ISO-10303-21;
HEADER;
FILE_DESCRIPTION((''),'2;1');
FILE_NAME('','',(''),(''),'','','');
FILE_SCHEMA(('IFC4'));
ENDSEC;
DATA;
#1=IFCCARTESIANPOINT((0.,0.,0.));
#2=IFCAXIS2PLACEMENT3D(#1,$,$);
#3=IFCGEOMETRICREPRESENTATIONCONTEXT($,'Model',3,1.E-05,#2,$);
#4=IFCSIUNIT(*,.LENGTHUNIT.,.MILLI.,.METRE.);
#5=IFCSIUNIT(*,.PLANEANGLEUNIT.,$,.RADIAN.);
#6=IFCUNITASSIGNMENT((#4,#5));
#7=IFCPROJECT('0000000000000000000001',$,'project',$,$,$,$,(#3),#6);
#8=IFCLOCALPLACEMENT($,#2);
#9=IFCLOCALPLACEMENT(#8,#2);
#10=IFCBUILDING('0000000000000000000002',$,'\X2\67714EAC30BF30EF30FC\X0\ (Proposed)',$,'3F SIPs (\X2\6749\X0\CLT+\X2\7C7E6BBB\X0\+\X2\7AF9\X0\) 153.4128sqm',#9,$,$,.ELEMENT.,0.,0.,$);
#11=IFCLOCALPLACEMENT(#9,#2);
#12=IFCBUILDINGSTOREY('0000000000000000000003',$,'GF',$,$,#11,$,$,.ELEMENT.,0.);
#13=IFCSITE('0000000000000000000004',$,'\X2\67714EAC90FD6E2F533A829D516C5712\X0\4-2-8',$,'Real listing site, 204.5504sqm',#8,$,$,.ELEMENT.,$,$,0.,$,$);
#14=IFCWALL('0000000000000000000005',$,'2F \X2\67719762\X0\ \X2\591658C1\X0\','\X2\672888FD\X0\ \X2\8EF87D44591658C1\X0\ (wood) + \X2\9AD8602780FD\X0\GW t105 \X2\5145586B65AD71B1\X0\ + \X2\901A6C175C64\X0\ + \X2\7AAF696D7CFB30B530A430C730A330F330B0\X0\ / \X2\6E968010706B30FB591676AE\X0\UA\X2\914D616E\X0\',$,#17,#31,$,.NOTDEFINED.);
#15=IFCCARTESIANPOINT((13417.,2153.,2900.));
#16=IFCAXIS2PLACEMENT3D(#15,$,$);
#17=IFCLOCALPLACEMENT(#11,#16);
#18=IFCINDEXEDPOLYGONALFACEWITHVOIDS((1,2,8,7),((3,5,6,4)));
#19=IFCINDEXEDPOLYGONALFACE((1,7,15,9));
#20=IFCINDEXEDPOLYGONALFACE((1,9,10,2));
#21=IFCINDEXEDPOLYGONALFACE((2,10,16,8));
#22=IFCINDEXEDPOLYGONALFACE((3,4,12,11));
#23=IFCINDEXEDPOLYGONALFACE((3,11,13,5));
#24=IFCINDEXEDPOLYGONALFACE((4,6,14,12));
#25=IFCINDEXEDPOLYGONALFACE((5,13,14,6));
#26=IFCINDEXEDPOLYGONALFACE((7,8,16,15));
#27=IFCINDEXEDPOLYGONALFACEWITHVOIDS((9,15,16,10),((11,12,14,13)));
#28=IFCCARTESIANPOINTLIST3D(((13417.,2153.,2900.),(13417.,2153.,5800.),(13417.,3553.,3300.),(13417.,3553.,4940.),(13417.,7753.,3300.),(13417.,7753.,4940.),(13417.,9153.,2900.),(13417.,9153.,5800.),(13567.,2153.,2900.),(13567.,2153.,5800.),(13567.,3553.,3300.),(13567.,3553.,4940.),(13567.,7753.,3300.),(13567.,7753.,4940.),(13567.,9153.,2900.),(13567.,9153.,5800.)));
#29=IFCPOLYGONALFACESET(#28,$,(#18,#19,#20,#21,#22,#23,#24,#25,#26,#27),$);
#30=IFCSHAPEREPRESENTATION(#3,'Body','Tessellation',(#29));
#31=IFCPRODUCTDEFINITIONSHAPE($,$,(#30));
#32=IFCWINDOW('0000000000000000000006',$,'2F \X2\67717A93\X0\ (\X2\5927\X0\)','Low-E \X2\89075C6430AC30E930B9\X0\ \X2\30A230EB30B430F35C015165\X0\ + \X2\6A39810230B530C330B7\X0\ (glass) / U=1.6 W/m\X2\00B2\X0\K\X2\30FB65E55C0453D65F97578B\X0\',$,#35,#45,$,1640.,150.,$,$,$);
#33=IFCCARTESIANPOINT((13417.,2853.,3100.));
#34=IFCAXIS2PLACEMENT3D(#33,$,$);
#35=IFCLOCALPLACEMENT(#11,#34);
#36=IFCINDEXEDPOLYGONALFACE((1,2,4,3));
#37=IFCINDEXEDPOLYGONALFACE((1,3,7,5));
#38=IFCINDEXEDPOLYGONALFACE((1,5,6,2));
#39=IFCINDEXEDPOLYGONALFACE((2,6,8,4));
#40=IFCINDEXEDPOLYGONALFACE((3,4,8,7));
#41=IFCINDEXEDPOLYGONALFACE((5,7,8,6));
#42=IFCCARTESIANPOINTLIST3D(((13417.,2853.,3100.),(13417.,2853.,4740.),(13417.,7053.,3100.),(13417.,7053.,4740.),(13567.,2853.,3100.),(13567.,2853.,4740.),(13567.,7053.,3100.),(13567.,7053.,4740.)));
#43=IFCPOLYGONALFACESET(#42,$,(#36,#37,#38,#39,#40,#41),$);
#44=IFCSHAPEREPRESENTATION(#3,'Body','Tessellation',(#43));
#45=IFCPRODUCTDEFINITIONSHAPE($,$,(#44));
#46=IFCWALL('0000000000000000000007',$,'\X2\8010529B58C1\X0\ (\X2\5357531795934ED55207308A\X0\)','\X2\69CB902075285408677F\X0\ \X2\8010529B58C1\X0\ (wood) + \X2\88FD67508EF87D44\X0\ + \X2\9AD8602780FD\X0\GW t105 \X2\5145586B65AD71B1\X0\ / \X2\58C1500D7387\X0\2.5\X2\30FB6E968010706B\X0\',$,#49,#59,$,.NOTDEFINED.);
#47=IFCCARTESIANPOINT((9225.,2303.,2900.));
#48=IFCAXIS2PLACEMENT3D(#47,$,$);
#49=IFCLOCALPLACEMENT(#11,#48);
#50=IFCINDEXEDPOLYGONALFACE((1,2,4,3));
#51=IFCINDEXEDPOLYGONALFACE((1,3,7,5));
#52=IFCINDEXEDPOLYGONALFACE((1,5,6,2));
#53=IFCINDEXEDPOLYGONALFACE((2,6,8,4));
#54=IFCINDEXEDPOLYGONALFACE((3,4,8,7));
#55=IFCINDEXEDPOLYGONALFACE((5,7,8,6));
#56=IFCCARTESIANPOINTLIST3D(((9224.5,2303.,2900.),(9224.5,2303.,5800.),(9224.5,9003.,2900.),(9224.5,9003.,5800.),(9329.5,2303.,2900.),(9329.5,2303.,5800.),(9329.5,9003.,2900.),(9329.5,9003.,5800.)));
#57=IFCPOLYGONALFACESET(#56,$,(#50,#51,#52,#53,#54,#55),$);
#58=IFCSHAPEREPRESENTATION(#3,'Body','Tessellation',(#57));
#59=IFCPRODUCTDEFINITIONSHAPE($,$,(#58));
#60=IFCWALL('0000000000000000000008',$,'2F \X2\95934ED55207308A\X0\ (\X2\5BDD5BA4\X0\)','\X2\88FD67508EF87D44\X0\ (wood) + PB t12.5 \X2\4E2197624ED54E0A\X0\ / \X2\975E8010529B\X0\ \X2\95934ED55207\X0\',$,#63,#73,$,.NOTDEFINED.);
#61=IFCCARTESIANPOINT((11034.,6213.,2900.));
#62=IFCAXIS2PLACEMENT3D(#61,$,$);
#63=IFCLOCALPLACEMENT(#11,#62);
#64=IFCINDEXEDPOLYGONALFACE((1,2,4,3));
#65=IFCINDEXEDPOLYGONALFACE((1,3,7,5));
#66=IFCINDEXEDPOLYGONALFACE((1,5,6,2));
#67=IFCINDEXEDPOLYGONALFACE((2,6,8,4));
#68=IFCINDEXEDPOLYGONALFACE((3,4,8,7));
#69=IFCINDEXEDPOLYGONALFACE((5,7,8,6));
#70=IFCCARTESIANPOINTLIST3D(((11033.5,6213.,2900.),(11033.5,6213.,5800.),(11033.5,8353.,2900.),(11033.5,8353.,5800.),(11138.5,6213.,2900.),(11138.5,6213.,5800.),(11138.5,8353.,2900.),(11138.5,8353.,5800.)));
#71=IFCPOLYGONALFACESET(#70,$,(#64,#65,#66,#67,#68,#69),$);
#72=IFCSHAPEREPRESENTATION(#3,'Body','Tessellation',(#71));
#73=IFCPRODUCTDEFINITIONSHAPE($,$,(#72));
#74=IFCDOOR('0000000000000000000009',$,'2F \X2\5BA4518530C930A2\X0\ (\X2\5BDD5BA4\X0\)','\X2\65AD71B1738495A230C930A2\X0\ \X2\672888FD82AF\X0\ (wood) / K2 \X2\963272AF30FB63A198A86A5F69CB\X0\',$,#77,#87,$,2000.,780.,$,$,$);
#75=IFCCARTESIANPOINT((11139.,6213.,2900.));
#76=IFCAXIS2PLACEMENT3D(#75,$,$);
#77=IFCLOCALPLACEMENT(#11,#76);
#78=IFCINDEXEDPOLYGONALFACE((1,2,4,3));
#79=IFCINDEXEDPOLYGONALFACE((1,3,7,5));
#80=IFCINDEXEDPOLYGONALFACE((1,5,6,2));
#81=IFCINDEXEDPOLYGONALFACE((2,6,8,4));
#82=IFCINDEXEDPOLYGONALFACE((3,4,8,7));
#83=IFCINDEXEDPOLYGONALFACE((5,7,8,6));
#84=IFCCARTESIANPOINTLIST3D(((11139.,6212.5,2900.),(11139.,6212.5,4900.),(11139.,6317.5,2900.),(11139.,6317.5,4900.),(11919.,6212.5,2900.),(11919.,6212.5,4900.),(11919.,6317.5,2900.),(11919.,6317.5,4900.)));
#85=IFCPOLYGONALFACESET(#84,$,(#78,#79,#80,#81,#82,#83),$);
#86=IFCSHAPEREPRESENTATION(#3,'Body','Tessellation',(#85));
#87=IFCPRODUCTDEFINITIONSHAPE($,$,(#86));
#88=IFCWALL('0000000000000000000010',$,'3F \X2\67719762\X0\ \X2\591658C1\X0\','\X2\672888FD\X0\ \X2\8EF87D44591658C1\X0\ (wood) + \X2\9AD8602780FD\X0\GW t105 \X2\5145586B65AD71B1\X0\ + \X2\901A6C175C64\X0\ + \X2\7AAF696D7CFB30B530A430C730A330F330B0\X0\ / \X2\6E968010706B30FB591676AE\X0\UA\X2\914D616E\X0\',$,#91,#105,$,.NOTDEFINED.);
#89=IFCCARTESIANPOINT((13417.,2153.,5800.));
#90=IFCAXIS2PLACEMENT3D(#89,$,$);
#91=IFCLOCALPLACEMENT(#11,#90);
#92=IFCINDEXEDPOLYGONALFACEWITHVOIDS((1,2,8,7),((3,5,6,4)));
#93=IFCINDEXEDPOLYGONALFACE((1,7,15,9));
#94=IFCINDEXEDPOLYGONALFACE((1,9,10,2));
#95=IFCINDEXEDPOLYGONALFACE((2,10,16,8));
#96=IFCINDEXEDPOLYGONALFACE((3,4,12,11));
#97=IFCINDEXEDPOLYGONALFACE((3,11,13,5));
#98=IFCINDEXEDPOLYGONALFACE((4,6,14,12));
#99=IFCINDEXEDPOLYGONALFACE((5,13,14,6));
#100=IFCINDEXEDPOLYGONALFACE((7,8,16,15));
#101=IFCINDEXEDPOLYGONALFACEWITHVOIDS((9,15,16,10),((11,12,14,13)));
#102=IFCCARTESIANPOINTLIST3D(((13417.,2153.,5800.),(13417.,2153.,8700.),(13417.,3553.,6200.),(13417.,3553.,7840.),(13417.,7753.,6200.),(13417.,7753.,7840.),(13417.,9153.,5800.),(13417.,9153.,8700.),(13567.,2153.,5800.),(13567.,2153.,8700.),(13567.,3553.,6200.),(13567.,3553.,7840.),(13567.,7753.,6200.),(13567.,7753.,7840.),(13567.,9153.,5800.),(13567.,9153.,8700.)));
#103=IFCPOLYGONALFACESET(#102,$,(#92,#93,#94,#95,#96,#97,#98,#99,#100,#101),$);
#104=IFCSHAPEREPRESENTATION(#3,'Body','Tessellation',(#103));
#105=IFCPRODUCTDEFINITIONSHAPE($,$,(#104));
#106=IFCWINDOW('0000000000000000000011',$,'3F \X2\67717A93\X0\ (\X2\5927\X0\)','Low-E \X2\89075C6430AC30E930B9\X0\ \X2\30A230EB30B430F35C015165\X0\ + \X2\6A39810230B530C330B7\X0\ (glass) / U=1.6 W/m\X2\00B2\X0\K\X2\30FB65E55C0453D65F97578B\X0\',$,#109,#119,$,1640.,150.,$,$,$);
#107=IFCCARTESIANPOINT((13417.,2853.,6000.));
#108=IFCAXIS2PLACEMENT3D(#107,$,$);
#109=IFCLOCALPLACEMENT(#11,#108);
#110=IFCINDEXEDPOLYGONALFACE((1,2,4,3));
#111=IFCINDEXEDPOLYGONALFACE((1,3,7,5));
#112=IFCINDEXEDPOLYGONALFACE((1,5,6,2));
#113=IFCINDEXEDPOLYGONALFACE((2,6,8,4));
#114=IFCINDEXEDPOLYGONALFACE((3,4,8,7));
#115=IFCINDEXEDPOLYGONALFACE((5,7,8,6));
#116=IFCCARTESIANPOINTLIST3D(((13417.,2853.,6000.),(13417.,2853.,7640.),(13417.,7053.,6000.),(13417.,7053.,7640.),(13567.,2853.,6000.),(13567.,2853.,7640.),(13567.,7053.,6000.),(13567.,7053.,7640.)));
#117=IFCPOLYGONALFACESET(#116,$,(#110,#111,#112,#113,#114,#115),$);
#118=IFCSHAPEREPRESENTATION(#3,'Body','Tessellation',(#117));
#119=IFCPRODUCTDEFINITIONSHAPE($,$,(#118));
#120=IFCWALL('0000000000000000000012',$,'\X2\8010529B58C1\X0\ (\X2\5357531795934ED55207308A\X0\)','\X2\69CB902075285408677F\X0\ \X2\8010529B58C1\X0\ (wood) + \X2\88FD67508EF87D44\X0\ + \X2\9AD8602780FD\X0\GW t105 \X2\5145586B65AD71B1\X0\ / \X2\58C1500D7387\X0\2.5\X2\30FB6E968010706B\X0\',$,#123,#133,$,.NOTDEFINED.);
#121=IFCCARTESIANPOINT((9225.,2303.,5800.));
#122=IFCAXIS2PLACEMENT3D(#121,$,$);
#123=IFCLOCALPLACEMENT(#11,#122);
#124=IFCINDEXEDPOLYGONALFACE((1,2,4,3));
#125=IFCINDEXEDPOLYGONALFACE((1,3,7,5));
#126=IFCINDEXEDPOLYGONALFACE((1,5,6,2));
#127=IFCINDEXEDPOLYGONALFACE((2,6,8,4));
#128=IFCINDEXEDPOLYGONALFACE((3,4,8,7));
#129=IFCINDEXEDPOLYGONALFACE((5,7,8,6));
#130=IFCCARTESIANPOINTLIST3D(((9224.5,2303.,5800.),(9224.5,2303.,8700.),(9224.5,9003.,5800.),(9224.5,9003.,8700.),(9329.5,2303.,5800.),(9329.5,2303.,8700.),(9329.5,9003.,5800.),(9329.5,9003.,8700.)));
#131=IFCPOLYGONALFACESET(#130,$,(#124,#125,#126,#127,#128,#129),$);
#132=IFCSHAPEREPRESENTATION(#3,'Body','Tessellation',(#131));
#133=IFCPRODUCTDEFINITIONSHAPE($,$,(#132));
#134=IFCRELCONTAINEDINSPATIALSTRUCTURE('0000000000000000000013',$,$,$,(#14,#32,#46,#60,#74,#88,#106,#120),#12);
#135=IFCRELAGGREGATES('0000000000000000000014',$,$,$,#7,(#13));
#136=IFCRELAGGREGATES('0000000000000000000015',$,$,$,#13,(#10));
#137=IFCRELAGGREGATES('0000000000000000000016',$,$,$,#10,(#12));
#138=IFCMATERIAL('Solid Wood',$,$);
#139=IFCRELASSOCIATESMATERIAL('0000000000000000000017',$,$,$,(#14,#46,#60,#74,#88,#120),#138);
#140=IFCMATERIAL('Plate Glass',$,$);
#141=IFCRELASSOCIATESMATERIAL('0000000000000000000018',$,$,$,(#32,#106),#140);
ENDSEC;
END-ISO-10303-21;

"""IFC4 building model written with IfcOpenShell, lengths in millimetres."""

from ifc_helpers import new_model, si_unit, frame, frame_2d, origin, place, context, project, spatial, rectangle, extrude, material, element, fill, save


model = new_model("IFC4")

# Units and contexts
model_context = context("Model", 3, precision=1e-05, world=origin())
ifc_project = project(units=[si_unit("LENGTHUNIT", "METRE", prefix="MILLI"), si_unit("PLANEANGLEUNIT", "RADIAN")], contexts=[model_context])

# Site, building, storey
site_placement = place(None, origin())
site = spatial("IfcSite", under=ifc_project, at=site_placement, Name="東京都港区芝公園4-2-8", ObjectType="Real listing site, 204.5504sqm", CompositionType="ELEMENT", RefElevation=0.0)
building_placement = place(site_placement, origin())
building = spatial("IfcBuilding", under=site, at=building_placement, Name="東京タワー (Proposed)", ObjectType="3F SIPs (杉CLT+籾殻+竹) 153.4128sqm", CompositionType="ELEMENT", ElevationOfRefHeight=0.0, ElevationOfTerrain=0.0)
storey_placement = place(building_placement, origin())
storey = spatial("IfcBuildingStorey", under=building, at=storey_placement, Name="GF", CompositionType="ELEMENT", Elevation=0.0)

# Wall, opening, window
ifc_material_1 = material(Name="Solid Wood")
wall_1_placement = place(storey_placement, frame((13417.0, 2153.0, 2900.0)))
wall_1 = element("IfcWall", 1, at=wall_1_placement, inside=storey, material=ifc_material_1, Name="2F 東面 外壁", Description="木製 軸組外壁 (wood) + 高性能GW t105 充填断熱 + 通気層 + 窯業系サイディング / 準耐火・外皮UA配慮", PredefinedType="NOTDEFINED", context=model_context, shape_type="SweptSolid", body=[
    extrude(rectangle(XDim=150.0, YDim=7000.0, at=frame_2d((75.0, 3500.0))), frame((13417.0, 2153.0, 2900.0)), (0.0, 0.0, 1.0), 2900.0),
])
opening_1_placement = place(storey_placement, frame((13417.0, 2853.0, 3100.0)))
opening_1 = element("IfcOpeningElement", 2, at=opening_1_placement, cuts=wall_1, PredefinedType="NOTDEFINED", context=model_context, shape_type="SweptSolid", body=[
    extrude(rectangle(XDim=150.0, YDim=4200.0, at=frame_2d((75.0, 2100.0))), frame((13417.0, 2853.0, 3100.0)), (0.0, 0.0, 1.0), 1640.0),
])
ifc_material_2 = material(Name="Plate Glass")
window_1_placement = place(storey_placement, frame((13417.0, 2853.0, 3100.0)))
window_1 = element("IfcWindow", 3, at=window_1_placement, inside=storey, material=ifc_material_2, Name="2F 東窓 (大)", Description="Low-E 複層ガラス アルゴン封入 + 樹脂サッシ (glass) / U=1.6 W/m²K・日射取得型", OverallHeight=1640.0, OverallWidth=150.0, context=model_context, shape_type="SweptSolid", body=[
    extrude(rectangle(XDim=150.0, YDim=4200.0, at=frame_2d((75.0, 2100.0))), frame((13417.0, 2853.0, 3100.0)), (0.0, 0.0, 1.0), 1640.0),
])
fill(opening_1, window_1)

# Walls
wall_2_placement = place(storey_placement, frame((9225.0, 2303.0, 2900.0)))
element("IfcWall", 4, at=wall_2_placement, inside=storey, material=ifc_material_1, Name="耐力壁 (南北間仕切り)", Description="構造用合板 耐力壁 (wood) + 製材軸組 + 高性能GW t105 充填断熱 / 壁倍率2.5・準耐火", PredefinedType="NOTDEFINED", context=model_context, shape_type="SweptSolid", body=[
    extrude(rectangle(XDim=105.0, YDim=6700.0, at=frame_2d((52.0, 3350.0))), frame((9225.0, 2303.0, 2900.0)), (0.0, 0.0, 1.0), 2900.0),
])
wall_3_placement = place(storey_placement, frame((11034.0, 6213.0, 2900.0)))
element("IfcWall", 5, at=wall_3_placement, inside=storey, material=ifc_material_1, Name="2F 間仕切り (寝室)", Description="製材軸組 (wood) + PB t12.5 両面仕上 / 非耐力 間仕切", PredefinedType="NOTDEFINED", context=model_context, shape_type="SweptSolid", body=[
    extrude(rectangle(XDim=105.0, YDim=2140.0, at=frame_2d((52.0, 1070.0))), frame((11034.0, 6213.0, 2900.0)), (0.0, 0.0, 1.0), 2900.0),
])

# Door
door_1_placement = place(storey_placement, frame((11139.0, 6213.0, 2900.0)))
element("IfcDoor", 6, at=door_1_placement, inside=storey, material=ifc_material_1, Name="2F 室内ドア (寝室)", Description="断熱玄関ドア 木製芯 (wood) / K2 防犯・採風機構", OverallHeight=2000.0, OverallWidth=780.0, context=model_context, shape_type="SweptSolid", body=[
    extrude(rectangle(XDim=780.0, YDim=105.0, at=frame_2d((390.0, 52.0))), frame((11139.0, 6213.0, 2900.0)), (0.0, 0.0, 1.0), 2000.0),
])

# Wall, opening, window
wall_4_placement = place(storey_placement, frame((13417.0, 2153.0, 5800.0)))
wall_4 = element("IfcWall", 7, at=wall_4_placement, inside=storey, material=ifc_material_1, Name="3F 東面 外壁", Description="木製 軸組外壁 (wood) + 高性能GW t105 充填断熱 + 通気層 + 窯業系サイディング / 準耐火・外皮UA配慮", PredefinedType="NOTDEFINED", context=model_context, shape_type="SweptSolid", body=[
    extrude(rectangle(XDim=150.0, YDim=7000.0, at=frame_2d((75.0, 3500.0))), frame((13417.0, 2153.0, 5800.0)), (0.0, 0.0, 1.0), 2900.0),
])
opening_2_placement = place(storey_placement, frame((13417.0, 2853.0, 6000.0)))
opening_2 = element("IfcOpeningElement", 8, at=opening_2_placement, cuts=wall_4, PredefinedType="NOTDEFINED", context=model_context, shape_type="SweptSolid", body=[
    extrude(rectangle(XDim=150.0, YDim=4200.0, at=frame_2d((75.0, 2100.0))), frame((13417.0, 2853.0, 6000.0)), (0.0, 0.0, 1.0), 1640.0),
])
window_2_placement = place(storey_placement, frame((13417.0, 2853.0, 6000.0)))
window_2 = element("IfcWindow", 9, at=window_2_placement, inside=storey, material=ifc_material_2, Name="3F 東窓 (大)", Description="Low-E 複層ガラス アルゴン封入 + 樹脂サッシ (glass) / U=1.6 W/m²K・日射取得型", OverallHeight=1640.0, OverallWidth=150.0, context=model_context, shape_type="SweptSolid", body=[
    extrude(rectangle(XDim=150.0, YDim=4200.0, at=frame_2d((75.0, 2100.0))), frame((13417.0, 2853.0, 6000.0)), (0.0, 0.0, 1.0), 1640.0),
])
fill(opening_2, window_2)

# Wall
wall_5_placement = place(storey_placement, frame((9225.0, 2303.0, 5800.0)))
element("IfcWall", 10, at=wall_5_placement, inside=storey, material=ifc_material_1, Name="耐力壁 (南北間仕切り)", Description="構造用合板 耐力壁 (wood) + 製材軸組 + 高性能GW t105 充填断熱 / 壁倍率2.5・準耐火", PredefinedType="NOTDEFINED", context=model_context, shape_type="SweptSolid", body=[
    extrude(rectangle(XDim=105.0, YDim=6700.0, at=frame_2d((52.0, 3350.0))), frame((9225.0, 2303.0, 5800.0)), (0.0, 0.0, 1.0), 2900.0),
])

save(model, "model.ifc")
